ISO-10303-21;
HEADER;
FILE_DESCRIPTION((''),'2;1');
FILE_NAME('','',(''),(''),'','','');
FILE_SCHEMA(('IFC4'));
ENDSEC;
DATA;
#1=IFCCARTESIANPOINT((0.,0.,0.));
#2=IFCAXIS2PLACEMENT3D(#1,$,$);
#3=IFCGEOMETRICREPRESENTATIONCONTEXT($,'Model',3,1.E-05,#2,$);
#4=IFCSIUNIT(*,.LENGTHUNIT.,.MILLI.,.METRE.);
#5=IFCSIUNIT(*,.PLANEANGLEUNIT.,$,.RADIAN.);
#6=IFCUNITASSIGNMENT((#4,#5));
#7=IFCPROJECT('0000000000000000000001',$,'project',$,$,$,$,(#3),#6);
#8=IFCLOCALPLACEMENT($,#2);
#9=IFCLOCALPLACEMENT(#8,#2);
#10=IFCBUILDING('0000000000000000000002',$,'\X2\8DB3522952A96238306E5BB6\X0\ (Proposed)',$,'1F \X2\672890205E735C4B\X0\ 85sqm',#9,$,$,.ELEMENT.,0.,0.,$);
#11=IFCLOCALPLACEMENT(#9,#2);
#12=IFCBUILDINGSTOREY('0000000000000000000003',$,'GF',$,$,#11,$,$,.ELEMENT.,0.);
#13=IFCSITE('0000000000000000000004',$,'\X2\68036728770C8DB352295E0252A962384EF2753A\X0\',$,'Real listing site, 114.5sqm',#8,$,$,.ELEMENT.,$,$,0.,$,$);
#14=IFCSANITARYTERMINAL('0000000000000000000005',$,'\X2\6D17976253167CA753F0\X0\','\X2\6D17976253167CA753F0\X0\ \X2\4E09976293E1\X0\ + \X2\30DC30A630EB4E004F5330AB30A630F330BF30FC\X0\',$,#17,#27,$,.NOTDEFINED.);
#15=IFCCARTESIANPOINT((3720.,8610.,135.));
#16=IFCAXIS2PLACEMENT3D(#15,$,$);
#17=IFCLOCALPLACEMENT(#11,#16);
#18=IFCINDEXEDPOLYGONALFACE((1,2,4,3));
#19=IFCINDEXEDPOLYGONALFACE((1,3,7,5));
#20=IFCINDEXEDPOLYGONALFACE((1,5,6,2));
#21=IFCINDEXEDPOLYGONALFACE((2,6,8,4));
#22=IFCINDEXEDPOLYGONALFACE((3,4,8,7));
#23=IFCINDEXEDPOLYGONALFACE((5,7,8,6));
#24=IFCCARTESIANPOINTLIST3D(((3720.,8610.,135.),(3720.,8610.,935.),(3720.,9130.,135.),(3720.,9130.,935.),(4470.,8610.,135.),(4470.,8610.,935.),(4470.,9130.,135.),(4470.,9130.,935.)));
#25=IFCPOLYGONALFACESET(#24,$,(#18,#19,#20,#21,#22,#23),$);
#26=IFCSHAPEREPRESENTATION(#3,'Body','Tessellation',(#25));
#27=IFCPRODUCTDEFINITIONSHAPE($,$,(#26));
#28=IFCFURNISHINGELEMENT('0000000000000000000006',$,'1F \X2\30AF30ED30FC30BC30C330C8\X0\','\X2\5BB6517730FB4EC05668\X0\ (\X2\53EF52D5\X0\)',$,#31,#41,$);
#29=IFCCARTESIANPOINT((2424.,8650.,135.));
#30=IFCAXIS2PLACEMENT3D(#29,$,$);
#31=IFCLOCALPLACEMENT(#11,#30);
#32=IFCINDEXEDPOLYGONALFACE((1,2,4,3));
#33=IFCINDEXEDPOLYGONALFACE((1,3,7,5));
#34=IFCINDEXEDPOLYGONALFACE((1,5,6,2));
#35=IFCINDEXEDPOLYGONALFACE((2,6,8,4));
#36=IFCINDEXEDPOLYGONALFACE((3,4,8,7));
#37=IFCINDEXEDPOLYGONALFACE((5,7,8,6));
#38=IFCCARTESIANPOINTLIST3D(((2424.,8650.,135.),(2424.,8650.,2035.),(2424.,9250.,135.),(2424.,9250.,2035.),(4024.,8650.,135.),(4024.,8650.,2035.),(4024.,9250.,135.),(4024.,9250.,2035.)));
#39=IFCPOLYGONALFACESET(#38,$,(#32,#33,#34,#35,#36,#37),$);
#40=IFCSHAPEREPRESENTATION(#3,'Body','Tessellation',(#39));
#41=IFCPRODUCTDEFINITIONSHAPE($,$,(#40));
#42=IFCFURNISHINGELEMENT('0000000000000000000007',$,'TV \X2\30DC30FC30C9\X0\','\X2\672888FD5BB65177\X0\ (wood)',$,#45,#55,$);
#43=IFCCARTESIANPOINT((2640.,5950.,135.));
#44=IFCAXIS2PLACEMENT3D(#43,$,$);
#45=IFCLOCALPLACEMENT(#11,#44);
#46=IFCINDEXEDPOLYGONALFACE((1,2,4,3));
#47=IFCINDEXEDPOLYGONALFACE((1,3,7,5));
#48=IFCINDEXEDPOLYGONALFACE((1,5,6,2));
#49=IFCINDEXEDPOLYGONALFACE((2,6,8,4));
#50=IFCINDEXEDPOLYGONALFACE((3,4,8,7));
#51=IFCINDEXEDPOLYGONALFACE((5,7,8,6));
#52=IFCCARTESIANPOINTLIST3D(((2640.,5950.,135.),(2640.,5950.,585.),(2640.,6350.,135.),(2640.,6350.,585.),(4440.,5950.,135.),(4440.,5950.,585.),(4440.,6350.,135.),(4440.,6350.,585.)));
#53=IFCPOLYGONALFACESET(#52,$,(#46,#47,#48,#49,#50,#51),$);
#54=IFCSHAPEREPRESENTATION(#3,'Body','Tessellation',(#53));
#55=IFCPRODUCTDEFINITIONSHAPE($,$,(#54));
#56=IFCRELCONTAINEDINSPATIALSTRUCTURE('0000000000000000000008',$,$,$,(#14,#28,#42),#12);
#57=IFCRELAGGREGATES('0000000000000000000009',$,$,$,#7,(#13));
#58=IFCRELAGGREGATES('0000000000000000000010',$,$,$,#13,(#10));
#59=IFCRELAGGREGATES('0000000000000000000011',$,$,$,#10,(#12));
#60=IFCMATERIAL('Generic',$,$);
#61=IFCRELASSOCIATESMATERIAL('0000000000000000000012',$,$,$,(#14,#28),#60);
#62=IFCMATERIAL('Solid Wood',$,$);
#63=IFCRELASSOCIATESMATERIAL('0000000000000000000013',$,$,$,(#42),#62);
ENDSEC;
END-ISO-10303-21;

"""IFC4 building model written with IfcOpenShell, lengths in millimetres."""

from ifc_helpers import new_model, si_unit, frame, frame_2d, origin, place, context, project, spatial, rectangle, extrude, material, element, save


model = new_model("IFC4")

# Units and contexts
model_context = context("Model", 3, precision=1e-05, world=origin())
ifc_project = project(units=[si_unit("LENGTHUNIT", "METRE", prefix="MILLI"), si_unit("PLANEANGLEUNIT", "RADIAN")], contexts=[model_context])

# Site, building, storey
site_placement = place(None, origin())
site = spatial("IfcSite", under=ifc_project, at=site_placement, Name="栃木県足利市助戸仲町", ObjectType="Real listing site, 114.5sqm", CompositionType="ELEMENT", RefElevation=0.0)
building_placement = place(site_placement, origin())
building = spatial("IfcBuilding", under=site, at=building_placement, Name="足利助戸の家 (Proposed)", ObjectType="1F 木造平屋 85sqm", CompositionType="ELEMENT", ElevationOfRefHeight=0.0, ElevationOfTerrain=0.0)
storey_placement = place(building_placement, origin())
storey = spatial("IfcBuildingStorey", under=building, at=storey_placement, Name="GF", CompositionType="ELEMENT", Elevation=0.0)

# Shared definitions
ifc_material_1 = material(Name="Solid Wood")

# Shared definitions
ifc_material_2 = material(Name="Generic")

# Sanitary terminal
sanitary_terminal_1_placement = place(storey_placement, frame((3720.0, 8610.0, 135.0)))
element("IfcSanitaryTerminal", 1, at=sanitary_terminal_1_placement, inside=storey, material=ifc_material_2, Name="洗面化粧台", Description="洗面化粧台 三面鏡 + ボウル一体カウンター", PredefinedType="NOTDEFINED", context=model_context, shape_type="SweptSolid", body=[
    extrude(rectangle(XDim=750.0, YDim=520.0, at=frame_2d((375.0, 260.0))), frame((3720.0, 8610.0, 135.0)), (0.0, 0.0, 1.0), 800.0),
])

# Furnishing elements
furnishing_1_placement = place(storey_placement, frame((2424.0, 8650.0, 135.0)))
element("IfcFurnishingElement", 2, at=furnishing_1_placement, inside=storey, material=ifc_material_2, Name="1F クローゼット", Description="家具・什器 (可動)", context=model_context, shape_type="SweptSolid", body=[
    extrude(rectangle(XDim=1600.0, YDim=600.0, at=frame_2d((800.0, 300.0))), frame((2424.0, 8650.0, 135.0)), (0.0, 0.0, 1.0), 1900.0),
])
furnishing_2_placement = place(storey_placement, frame((2640.0, 5950.0, 135.0)))
element("IfcFurnishingElement", 3, at=furnishing_2_placement, inside=storey, material=ifc_material_1, Name="TV ボード", Description="木製家具 (wood)", context=model_context, shape_type="SweptSolid", body=[
    extrude(rectangle(XDim=1800.0, YDim=400.0, at=frame_2d((900.0, 200.0))), frame((2640.0, 5950.0, 135.0)), (0.0, 0.0, 1.0), 450.0),
])

save(model, "model.ifc")
